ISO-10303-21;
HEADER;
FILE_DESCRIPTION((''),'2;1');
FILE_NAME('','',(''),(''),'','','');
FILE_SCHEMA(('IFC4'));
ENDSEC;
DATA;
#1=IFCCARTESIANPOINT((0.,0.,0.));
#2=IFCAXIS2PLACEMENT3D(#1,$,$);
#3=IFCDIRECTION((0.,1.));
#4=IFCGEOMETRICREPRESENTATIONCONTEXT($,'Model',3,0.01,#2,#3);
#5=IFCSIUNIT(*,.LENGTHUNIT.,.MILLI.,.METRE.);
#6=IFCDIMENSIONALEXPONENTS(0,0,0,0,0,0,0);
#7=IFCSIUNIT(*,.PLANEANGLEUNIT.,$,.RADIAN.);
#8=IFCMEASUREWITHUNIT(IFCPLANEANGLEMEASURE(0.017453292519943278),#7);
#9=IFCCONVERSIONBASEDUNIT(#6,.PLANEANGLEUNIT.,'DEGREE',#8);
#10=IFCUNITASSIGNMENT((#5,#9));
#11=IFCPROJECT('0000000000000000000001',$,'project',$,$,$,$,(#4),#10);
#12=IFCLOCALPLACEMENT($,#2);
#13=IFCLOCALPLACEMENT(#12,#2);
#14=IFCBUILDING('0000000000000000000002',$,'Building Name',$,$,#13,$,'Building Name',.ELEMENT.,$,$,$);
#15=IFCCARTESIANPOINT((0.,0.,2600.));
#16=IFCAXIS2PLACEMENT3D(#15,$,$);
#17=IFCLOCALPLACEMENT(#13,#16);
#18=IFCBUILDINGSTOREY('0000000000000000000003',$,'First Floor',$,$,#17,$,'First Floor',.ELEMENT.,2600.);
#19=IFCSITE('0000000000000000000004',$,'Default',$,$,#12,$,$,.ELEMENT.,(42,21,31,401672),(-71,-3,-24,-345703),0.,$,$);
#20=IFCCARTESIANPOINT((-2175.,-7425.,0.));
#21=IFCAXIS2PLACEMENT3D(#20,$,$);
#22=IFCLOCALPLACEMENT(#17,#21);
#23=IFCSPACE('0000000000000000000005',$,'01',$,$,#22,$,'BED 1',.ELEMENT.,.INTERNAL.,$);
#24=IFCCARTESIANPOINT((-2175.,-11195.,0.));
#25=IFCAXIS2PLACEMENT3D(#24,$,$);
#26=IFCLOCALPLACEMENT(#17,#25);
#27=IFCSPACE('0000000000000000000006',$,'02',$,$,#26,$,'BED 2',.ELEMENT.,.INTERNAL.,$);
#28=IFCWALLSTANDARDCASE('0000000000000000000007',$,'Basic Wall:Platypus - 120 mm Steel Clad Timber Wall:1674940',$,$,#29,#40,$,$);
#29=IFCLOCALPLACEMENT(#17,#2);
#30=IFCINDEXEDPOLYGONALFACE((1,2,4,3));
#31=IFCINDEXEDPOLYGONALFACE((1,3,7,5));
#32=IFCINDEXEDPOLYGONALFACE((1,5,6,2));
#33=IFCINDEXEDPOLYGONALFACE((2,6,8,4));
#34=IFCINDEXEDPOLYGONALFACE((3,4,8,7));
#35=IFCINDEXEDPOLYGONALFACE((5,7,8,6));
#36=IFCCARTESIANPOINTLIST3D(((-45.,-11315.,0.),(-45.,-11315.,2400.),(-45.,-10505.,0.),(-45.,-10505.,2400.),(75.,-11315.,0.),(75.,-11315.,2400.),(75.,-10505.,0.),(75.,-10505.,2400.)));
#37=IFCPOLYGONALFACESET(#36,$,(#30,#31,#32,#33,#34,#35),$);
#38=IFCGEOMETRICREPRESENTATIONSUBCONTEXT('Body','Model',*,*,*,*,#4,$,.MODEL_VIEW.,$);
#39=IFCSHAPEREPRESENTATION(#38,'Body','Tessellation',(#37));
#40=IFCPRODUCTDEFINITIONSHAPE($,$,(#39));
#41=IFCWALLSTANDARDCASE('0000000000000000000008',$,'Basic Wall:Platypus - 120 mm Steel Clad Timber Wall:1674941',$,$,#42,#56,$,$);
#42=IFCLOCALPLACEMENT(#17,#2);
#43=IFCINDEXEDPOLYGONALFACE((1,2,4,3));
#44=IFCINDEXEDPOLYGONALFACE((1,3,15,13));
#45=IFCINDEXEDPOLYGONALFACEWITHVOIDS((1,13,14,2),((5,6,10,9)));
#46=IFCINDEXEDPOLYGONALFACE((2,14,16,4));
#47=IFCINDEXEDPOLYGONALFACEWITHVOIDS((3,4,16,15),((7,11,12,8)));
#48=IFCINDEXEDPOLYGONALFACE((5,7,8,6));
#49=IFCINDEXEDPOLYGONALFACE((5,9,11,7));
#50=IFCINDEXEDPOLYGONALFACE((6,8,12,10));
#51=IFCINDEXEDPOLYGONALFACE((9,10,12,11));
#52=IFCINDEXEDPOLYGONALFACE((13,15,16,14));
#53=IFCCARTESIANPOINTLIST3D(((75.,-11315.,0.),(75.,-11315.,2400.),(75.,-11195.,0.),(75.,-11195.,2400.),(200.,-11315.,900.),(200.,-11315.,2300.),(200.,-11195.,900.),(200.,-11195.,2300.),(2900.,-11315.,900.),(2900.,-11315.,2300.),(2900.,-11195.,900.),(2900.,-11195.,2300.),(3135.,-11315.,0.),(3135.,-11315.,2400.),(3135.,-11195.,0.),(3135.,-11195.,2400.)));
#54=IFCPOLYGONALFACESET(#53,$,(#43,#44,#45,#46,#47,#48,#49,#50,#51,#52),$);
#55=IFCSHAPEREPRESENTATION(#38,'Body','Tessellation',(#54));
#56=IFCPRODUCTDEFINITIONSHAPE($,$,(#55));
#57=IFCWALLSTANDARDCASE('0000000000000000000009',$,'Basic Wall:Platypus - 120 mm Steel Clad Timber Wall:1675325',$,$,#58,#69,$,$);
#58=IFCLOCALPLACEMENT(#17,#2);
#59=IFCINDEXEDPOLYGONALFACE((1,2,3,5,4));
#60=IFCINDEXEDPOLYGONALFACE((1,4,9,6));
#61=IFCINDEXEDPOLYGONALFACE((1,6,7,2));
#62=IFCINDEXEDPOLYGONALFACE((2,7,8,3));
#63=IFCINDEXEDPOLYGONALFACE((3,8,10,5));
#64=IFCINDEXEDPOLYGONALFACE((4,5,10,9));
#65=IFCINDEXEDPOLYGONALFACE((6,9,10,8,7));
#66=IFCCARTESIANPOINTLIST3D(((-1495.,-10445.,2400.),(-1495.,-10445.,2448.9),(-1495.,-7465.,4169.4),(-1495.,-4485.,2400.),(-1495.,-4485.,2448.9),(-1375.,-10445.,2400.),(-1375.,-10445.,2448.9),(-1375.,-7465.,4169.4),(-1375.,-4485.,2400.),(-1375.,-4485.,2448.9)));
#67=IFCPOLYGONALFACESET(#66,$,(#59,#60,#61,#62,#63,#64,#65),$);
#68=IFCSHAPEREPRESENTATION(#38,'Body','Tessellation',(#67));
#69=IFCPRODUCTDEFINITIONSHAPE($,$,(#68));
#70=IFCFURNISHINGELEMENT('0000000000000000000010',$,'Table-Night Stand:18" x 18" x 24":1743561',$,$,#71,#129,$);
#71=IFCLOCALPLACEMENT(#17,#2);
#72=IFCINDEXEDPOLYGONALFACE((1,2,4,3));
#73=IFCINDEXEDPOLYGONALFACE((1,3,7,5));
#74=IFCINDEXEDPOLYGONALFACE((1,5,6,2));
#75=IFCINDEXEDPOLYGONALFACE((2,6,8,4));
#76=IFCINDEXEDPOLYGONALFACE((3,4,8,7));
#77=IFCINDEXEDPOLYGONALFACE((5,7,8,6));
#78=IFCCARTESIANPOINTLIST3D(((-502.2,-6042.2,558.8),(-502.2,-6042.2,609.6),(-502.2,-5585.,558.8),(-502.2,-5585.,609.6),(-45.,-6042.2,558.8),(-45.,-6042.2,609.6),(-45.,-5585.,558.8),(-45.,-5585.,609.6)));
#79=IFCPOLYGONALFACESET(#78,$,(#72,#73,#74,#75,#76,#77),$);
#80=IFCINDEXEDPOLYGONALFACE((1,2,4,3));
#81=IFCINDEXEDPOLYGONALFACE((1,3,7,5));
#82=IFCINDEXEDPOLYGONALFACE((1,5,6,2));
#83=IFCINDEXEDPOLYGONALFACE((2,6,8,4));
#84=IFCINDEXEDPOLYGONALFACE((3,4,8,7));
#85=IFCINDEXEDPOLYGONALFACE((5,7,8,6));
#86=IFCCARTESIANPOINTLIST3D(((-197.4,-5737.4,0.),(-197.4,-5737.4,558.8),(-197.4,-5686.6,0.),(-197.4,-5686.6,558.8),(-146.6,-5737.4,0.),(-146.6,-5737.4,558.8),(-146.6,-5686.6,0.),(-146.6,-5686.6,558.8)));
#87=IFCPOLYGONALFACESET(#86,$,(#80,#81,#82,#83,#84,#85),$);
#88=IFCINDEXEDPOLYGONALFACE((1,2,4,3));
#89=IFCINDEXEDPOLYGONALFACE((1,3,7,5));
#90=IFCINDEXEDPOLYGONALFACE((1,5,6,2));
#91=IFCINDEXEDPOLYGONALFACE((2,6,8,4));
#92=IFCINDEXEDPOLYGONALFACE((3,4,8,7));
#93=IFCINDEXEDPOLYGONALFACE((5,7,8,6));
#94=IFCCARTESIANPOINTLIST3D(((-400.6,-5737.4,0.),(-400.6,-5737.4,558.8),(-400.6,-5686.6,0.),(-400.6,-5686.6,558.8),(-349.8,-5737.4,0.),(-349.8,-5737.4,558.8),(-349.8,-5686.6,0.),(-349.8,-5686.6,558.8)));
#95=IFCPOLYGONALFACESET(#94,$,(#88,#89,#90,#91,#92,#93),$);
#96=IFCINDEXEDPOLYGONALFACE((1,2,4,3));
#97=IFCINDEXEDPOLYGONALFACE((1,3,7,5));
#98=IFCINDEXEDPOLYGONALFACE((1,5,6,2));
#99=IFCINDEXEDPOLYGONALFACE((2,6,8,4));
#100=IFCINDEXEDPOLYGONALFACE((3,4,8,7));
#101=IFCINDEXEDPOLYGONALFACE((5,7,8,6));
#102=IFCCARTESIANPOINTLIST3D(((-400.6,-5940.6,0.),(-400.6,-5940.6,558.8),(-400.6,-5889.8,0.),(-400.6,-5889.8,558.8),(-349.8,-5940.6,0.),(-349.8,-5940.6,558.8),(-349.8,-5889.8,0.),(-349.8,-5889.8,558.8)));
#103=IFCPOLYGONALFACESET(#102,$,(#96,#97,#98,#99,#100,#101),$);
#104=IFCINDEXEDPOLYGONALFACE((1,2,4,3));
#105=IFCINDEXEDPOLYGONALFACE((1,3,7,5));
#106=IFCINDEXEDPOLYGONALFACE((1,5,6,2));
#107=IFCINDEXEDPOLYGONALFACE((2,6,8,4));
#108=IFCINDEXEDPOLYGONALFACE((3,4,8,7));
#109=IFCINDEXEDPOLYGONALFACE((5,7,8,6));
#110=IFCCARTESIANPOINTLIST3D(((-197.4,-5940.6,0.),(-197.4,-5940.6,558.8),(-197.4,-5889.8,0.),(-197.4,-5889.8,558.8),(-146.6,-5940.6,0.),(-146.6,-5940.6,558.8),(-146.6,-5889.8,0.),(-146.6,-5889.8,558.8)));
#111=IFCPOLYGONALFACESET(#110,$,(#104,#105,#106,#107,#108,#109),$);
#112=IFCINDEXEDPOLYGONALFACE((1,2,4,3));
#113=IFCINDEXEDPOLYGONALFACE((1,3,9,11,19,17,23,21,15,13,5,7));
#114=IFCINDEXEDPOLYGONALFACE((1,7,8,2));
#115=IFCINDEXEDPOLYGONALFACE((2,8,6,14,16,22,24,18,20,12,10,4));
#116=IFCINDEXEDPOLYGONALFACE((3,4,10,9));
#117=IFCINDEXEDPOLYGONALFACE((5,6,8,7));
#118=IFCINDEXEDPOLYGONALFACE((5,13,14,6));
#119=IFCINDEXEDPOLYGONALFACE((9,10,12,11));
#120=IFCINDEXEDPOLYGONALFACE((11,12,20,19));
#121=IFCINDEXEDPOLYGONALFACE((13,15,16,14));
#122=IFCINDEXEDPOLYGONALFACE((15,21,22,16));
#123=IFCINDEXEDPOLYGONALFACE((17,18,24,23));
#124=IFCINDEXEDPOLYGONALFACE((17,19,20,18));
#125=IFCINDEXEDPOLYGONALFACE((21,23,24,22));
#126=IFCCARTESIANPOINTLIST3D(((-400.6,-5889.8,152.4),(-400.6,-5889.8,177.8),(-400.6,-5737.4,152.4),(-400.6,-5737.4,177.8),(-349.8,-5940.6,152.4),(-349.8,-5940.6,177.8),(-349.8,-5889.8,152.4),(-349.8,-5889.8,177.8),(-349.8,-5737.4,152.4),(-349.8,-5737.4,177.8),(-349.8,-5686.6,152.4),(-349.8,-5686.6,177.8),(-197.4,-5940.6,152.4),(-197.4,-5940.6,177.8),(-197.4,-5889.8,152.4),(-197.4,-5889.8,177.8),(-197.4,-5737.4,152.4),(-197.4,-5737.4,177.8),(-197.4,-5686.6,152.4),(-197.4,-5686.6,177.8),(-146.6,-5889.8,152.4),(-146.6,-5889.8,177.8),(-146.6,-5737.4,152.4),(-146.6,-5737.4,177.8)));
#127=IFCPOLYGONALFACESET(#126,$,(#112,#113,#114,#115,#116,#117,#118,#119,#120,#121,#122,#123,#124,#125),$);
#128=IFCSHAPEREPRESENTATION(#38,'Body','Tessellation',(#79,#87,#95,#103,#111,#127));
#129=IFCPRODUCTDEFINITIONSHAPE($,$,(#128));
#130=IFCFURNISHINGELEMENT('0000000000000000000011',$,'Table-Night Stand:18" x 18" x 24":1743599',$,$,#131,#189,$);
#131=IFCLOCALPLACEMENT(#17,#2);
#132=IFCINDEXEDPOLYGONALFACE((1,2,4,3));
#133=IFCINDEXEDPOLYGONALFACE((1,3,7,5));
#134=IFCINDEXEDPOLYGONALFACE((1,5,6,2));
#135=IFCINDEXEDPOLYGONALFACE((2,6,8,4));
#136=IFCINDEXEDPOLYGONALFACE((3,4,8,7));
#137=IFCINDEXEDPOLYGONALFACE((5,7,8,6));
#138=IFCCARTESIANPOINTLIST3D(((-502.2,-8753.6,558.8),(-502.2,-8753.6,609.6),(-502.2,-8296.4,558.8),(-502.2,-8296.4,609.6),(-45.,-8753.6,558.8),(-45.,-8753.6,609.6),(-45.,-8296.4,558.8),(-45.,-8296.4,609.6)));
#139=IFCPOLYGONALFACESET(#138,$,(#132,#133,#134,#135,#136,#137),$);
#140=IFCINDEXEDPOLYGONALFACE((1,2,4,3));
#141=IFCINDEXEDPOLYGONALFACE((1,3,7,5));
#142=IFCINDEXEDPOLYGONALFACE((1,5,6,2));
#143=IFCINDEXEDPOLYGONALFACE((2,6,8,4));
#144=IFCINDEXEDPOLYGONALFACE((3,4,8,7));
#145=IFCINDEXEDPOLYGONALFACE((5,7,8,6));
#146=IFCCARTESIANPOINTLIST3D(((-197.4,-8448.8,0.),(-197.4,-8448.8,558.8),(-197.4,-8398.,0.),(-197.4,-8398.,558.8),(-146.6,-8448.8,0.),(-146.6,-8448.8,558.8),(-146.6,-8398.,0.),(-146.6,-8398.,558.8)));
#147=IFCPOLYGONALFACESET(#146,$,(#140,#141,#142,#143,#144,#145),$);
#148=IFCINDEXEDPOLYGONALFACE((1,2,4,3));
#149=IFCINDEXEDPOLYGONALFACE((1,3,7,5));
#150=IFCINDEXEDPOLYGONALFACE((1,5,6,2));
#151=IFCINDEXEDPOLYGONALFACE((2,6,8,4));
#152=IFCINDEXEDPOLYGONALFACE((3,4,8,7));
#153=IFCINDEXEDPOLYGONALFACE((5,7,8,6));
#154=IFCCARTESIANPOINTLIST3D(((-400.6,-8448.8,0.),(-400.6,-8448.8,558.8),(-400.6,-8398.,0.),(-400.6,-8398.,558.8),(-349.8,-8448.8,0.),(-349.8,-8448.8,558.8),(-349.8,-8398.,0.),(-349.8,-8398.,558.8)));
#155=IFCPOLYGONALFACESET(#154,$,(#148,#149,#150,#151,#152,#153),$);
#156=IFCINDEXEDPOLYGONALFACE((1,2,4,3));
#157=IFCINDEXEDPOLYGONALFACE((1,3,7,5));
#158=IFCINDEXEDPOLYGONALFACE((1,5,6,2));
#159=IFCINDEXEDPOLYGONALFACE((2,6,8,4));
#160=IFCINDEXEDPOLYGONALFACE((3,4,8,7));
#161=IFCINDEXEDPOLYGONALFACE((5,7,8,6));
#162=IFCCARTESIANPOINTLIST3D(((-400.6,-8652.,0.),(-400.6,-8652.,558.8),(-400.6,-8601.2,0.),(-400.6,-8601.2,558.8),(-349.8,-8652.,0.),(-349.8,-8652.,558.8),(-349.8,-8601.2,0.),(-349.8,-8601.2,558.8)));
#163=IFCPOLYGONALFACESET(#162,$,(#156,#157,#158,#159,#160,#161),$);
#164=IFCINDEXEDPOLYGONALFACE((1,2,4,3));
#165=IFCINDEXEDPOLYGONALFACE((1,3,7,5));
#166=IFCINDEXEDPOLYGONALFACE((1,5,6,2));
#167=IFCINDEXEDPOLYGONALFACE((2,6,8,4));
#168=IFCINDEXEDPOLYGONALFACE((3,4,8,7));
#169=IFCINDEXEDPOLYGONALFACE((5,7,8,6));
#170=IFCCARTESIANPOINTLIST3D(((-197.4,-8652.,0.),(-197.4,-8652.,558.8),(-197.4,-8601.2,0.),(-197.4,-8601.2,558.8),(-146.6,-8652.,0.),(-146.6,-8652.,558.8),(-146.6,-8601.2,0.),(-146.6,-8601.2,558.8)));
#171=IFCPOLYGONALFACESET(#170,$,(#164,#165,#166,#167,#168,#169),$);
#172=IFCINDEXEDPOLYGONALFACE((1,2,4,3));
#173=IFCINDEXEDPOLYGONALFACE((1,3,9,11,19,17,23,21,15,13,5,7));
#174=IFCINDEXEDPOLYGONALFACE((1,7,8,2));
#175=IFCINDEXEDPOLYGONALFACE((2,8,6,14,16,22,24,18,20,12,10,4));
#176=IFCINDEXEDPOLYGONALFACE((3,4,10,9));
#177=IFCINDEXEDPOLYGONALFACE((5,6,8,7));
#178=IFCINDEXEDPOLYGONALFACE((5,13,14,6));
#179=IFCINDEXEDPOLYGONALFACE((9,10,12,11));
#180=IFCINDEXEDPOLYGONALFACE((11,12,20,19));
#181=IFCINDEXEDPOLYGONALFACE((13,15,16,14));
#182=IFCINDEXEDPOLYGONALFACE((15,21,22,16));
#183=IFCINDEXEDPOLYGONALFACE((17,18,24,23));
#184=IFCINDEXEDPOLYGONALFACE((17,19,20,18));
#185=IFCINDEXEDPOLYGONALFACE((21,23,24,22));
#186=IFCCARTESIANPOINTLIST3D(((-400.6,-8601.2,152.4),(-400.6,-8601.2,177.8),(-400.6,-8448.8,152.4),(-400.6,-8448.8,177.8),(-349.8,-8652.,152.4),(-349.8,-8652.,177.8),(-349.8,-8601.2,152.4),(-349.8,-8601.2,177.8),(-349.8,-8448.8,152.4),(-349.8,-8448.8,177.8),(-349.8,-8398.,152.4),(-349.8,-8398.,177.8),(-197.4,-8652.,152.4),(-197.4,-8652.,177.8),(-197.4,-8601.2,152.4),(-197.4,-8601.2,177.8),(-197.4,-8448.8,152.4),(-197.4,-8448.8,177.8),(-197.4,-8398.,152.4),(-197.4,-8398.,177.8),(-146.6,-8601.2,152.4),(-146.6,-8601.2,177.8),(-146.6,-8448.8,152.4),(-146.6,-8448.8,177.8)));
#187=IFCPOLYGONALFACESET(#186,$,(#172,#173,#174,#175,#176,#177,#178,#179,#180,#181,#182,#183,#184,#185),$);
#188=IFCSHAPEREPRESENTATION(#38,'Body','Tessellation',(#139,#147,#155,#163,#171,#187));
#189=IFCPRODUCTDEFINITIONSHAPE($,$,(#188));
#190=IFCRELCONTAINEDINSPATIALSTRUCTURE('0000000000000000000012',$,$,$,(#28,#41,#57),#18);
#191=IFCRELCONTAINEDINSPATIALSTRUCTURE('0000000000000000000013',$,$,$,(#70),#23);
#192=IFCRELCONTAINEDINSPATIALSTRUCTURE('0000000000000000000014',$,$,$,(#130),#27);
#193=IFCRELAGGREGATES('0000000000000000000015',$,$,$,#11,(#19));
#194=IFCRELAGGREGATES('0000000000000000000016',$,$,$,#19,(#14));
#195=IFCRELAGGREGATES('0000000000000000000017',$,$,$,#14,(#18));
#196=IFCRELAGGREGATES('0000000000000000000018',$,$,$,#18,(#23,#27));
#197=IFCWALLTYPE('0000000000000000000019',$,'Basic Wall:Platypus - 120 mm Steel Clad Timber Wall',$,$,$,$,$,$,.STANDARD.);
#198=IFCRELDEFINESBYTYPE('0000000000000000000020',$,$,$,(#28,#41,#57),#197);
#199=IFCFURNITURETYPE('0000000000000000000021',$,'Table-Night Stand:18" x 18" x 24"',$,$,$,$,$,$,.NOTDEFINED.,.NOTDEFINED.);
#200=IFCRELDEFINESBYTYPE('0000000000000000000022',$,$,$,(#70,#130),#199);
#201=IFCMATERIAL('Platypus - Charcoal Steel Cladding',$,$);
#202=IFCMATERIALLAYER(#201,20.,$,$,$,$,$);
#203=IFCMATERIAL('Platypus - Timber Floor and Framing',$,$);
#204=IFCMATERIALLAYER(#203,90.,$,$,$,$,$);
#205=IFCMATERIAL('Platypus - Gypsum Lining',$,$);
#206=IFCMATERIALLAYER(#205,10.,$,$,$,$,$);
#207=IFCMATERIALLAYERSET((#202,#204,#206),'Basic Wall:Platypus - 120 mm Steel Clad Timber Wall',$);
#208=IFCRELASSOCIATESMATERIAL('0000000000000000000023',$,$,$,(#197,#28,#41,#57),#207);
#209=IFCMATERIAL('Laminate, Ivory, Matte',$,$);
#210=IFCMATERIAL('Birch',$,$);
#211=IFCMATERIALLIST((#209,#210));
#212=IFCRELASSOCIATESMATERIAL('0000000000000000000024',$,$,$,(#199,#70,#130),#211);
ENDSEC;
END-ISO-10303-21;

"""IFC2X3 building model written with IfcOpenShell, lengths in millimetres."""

from ifc_helpers import new_model, entity, si_unit, converted_unit, direction, frame, frame_2d, origin, origin_2d_with_axis, place, context, subcontext, project, spatial, polyline, rectangle, outline, extrude, clip, halfspace, source, transform, mapped, material, material_list, layer, layer_set, layer_usage, type_object, type_shapes, element, save


model = new_model("IFC2X3")

# Units and contexts
model_context = context("Model", 3, precision=0.01, world=origin(), true_north=direction((0.0, 1.0)))
body_context = subcontext(model_context, "Body", "Model", "MODEL_VIEW")
ifc_project = project(units=[si_unit("LENGTHUNIT", "METRE", prefix="MILLI"), converted_unit("PLANEANGLEUNIT", "DEGREE", entity("IfcPlaneAngleMeasure", 0.017453292519943278), si_unit("PLANEANGLEUNIT", "RADIAN"), dimensions=[0, 0, 0, 0, 0, 0, 0])], contexts=[model_context])

# Site, building, storey
site_placement = place(None, origin())
site = spatial("IfcSite", under=ifc_project, at=site_placement, Name="Default", CompositionType="ELEMENT", RefLatitude=(42, 21, 31, 401672), RefLongitude=(-71, -3, -24, -345703), RefElevation=0.0)
building_placement = place(site_placement, origin())
building = spatial("IfcBuilding", under=site, at=building_placement, Name="Building Name", LongName="Building Name", CompositionType="ELEMENT")
storey_placement = place(building_placement, frame((0.0, 0.0, 2600.0)))
storey = spatial("IfcBuildingStorey", under=building, at=storey_placement, Name="First Floor", LongName="First Floor", CompositionType="ELEMENT", Elevation=2600.0)

# Shared definitions
ifc_material_1 = material(Name="Platypus - Timber Floor and Framing")

# Shared definitions
ifc_material_2 = material(Name="Platypus - Gypsum Lining")

# Shared definitions
ifc_material_3 = material(Name="Platypus - Charcoal Steel Cladding")
ifc_layer_1 = layer(ifc_material_3, 20.0)
ifc_layer_2 = layer(ifc_material_1, 90.0)
ifc_layer_3 = layer(ifc_material_2, 10.0)
ifc_layer_set_1 = layer_set([ifc_layer_1, ifc_layer_2, ifc_layer_3], Name="Basic Wall:Platypus - 120 mm Steel Clad Timber Wall")
wall_type_1 = type_object("IfcWallType", Name="Basic Wall:Platypus - 120 mm Steel Clad Timber Wall", PredefinedType="STANDARD", material=ifc_layer_set_1)

# Wall
ifc_layer_usage_1 = layer_usage(ifc_layer_set_1, "AXIS2", "POSITIVE", -60.0)
wall_1_placement = place(storey_placement, frame((15.0, -10505.0, 0.0), z_axis=(0.0, 0.0, 1.0), x_axis=(0.0, -1.0, 0.0)))
element("IfcWallStandardCase", 1, at=wall_1_placement, inside=storey, type_object=wall_type_1, material=ifc_layer_usage_1, Name="Basic Wall:Platypus - 120 mm Steel Clad Timber Wall:1674940", context=body_context, shape_type="SweptSolid", body=[
    extrude(rectangle(XDim=810.0, YDim=120.0, at=frame_2d((405.0, 0.0), x_axis=(-1.0, 0.0))), origin(), (0.0, 0.0, 1.0), 2400.0),
])

# Wall, opening
ifc_layer_usage_2 = layer_usage(ifc_layer_set_1, "AXIS2", "POSITIVE", -60.0)
wall_2_placement = place(storey_placement, frame((75.0, -11255.0, 0.0)))
wall_2 = element("IfcWallStandardCase", 2, at=wall_2_placement, inside=storey, type_object=wall_type_1, material=ifc_layer_usage_2, Name="Basic Wall:Platypus - 120 mm Steel Clad Timber Wall:1674941", context=body_context, shape_type="SweptSolid", body=[
    extrude(rectangle(XDim=3060.0, YDim=120.0, at=frame_2d((1530.0, 0.0), x_axis=(-1.0, 0.0))), origin(), (0.0, 0.0, 1.0), 2400.0),
])
opening_1_placement = place(wall_2_placement, frame((125.0, -60.0, 900.0)))
element("IfcOpeningElement", 3, at=opening_1_placement, cuts=wall_2, ObjectType="Opening", context=body_context, shape_type="SweptSolid", body=[
    extrude(rectangle(XDim=1400.0, YDim=2700.0, at=frame_2d((700.0, 1350.0), x_axis=(-1.0, 0.0))), frame((0.0, 0.0, 0.0), z_axis=(0.0, 1.0, 0.0), x_axis=(0.0, 0.0, 1.0)), (0.0, 0.0, 1.0), 120.0),
])

# Wall
ifc_layer_usage_3 = layer_usage(ifc_layer_set_1, "AXIS2", "POSITIVE", -60.0)
wall_3_placement = place(storey_placement, frame((-1435.0, -10445.0, 2400.0), z_axis=(0.0, 0.0, 1.0), x_axis=(0.0, 1.0, 0.0)))
element("IfcWallStandardCase", 4, at=wall_3_placement, inside=storey, type_object=wall_type_1, material=ifc_layer_usage_3, Name="Basic Wall:Platypus - 120 mm Steel Clad Timber Wall:1675325", context=body_context, shape_type="Clipping", body=[
    clip(clip(extrude(rectangle(XDim=5960.0, YDim=120.0, at=frame_2d((2980.0, 0.0), x_axis=(-1.0, 0.0))), origin(), (0.0, 0.0, 1.0), 1769.4), halfspace(frame((2980.0, -60.0, 1769.4), z_axis=(0.5, 0.0, 0.866025), x_axis=(0.0, 1.0, 0.0)), False)), halfspace(frame((0.0, -60.0, 48.9), z_axis=(-0.5, 0.0, 0.866025), x_axis=(0.0, 1.0, 0.0)), False)),
])

# Shared definitions
space_1_placement = place(storey_placement, frame((-2175.0, -7425.0, 0.0)))
space_1 = spatial("IfcSpace", under=storey, at=space_1_placement, Name="01", LongName="BED 1", CompositionType="ELEMENT", InteriorOrExteriorSpace="INTERNAL")

# Shared definitions
space_2_placement = place(storey_placement, frame((-2175.0, -11195.0, 0.0)))
space_2 = spatial("IfcSpace", under=storey, at=space_2_placement, Name="02", LongName="BED 2", CompositionType="ELEMENT", InteriorOrExteriorSpace="INTERNAL")

# Furnishing elements
ifc_material_4 = material(Name="Laminate, Ivory, Matte")
ifc_material_5 = material(Name="Birch")
ifc_material_list_1 = material_list([ifc_material_4, ifc_material_5])
furniture_type_1 = type_object("IfcFurnitureType", Name="Table-Night Stand:18\" x 18\" x 24\"", AssemblyPlace="NOTDEFINED", material=ifc_material_list_1)
shared_shape_1 = source(origin(), body_context, "Body", "SweptSolid", [
    extrude(rectangle(XDim=457.2, YDim=457.2, at=origin_2d_with_axis()), frame((232.3, 228.6, 558.8), z_axis=(0.0, 0.0, 1.0), x_axis=(0.0, 1.0, 0.0)), (0.0, 0.0, 1.0), 50.8),
    extrude(rectangle(XDim=50.8, YDim=50.8, at=origin_2d_with_axis()), frame((333.9, 330.2, 0.0), z_axis=(0.0, 0.0, 1.0), x_axis=(-1.0, 0.0, 0.0)), (0.0, 0.0, 1.0), 558.8),
    extrude(rectangle(XDim=50.8, YDim=50.8, at=frame_2d((0.0, 0.0), x_axis=(1.0, 0.0))), frame((130.7, 330.2, 0.0), z_axis=(0.0, 0.0, 1.0), x_axis=(-1.0, 0.0, 0.0)), (0.0, 0.0, 1.0), 558.8),
    extrude(rectangle(XDim=50.8, YDim=50.8, at=frame_2d((0.0, 0.0), x_axis=(1.0, 0.0))), frame((130.7, 127.0, 0.0), z_axis=(0.0, 0.0, 1.0), x_axis=(-1.0, 0.0, 0.0)), (0.0, 0.0, 1.0), 558.8),
    extrude(rectangle(XDim=50.8, YDim=50.8, at=frame_2d((0.0, 0.0), x_axis=(1.0, 0.0))), frame((333.9, 127.0, 0.0), z_axis=(0.0, 0.0, 1.0), x_axis=(-1.0, 0.0, 0.0)), (0.0, 0.0, 1.0), 558.8),
    extrude(outline(polyline([(-127.0, 76.2), (-127.0, -76.2), (-76.2, -76.2), (-76.2, -127.0), (76.2, -127.0), (76.2, -76.2), (127.0, -76.2), (127.0, 76.2), (76.2, 76.2), (76.2, 127.0), (-76.2, 127.0), (-76.2, 76.2), (-127.0, 76.2)])), frame((232.3, 228.6, 152.4), z_axis=(0.0, 0.0, -1.0), x_axis=(0.0, -1.0, 0.0)), (0.0, 0.0, -1.0), 25.4),
])
type_shapes(furniture_type_1, [shared_shape_1])
furnishing_1_placement = place(space_1_placement, frame((1669.1, 1382.8, 0.0)))
element("IfcFurnishingElement", 5, at=furnishing_1_placement, inside=space_1, type_object=furniture_type_1, material=ifc_material_list_1, Name="Table-Night Stand:18\" x 18\" x 24\":1743561", context=body_context, shape_type="MappedRepresentation", body=[
    mapped(shared_shape_1, transform((0.0, 0.0, 0.0), scale=1.0)),
])
furnishing_2_placement = place(space_2_placement, frame((1669.1, 2441.4, 0.0)))
element("IfcFurnishingElement", 6, at=furnishing_2_placement, inside=space_2, type_object=furniture_type_1, material=ifc_material_list_1, Name="Table-Night Stand:18\" x 18\" x 24\":1743599", context=body_context, shape_type="MappedRepresentation", body=[
    mapped(shared_shape_1, transform((0.0, 0.0, 0.0), scale=1.0)),
])

save(model, "model.ifc")
